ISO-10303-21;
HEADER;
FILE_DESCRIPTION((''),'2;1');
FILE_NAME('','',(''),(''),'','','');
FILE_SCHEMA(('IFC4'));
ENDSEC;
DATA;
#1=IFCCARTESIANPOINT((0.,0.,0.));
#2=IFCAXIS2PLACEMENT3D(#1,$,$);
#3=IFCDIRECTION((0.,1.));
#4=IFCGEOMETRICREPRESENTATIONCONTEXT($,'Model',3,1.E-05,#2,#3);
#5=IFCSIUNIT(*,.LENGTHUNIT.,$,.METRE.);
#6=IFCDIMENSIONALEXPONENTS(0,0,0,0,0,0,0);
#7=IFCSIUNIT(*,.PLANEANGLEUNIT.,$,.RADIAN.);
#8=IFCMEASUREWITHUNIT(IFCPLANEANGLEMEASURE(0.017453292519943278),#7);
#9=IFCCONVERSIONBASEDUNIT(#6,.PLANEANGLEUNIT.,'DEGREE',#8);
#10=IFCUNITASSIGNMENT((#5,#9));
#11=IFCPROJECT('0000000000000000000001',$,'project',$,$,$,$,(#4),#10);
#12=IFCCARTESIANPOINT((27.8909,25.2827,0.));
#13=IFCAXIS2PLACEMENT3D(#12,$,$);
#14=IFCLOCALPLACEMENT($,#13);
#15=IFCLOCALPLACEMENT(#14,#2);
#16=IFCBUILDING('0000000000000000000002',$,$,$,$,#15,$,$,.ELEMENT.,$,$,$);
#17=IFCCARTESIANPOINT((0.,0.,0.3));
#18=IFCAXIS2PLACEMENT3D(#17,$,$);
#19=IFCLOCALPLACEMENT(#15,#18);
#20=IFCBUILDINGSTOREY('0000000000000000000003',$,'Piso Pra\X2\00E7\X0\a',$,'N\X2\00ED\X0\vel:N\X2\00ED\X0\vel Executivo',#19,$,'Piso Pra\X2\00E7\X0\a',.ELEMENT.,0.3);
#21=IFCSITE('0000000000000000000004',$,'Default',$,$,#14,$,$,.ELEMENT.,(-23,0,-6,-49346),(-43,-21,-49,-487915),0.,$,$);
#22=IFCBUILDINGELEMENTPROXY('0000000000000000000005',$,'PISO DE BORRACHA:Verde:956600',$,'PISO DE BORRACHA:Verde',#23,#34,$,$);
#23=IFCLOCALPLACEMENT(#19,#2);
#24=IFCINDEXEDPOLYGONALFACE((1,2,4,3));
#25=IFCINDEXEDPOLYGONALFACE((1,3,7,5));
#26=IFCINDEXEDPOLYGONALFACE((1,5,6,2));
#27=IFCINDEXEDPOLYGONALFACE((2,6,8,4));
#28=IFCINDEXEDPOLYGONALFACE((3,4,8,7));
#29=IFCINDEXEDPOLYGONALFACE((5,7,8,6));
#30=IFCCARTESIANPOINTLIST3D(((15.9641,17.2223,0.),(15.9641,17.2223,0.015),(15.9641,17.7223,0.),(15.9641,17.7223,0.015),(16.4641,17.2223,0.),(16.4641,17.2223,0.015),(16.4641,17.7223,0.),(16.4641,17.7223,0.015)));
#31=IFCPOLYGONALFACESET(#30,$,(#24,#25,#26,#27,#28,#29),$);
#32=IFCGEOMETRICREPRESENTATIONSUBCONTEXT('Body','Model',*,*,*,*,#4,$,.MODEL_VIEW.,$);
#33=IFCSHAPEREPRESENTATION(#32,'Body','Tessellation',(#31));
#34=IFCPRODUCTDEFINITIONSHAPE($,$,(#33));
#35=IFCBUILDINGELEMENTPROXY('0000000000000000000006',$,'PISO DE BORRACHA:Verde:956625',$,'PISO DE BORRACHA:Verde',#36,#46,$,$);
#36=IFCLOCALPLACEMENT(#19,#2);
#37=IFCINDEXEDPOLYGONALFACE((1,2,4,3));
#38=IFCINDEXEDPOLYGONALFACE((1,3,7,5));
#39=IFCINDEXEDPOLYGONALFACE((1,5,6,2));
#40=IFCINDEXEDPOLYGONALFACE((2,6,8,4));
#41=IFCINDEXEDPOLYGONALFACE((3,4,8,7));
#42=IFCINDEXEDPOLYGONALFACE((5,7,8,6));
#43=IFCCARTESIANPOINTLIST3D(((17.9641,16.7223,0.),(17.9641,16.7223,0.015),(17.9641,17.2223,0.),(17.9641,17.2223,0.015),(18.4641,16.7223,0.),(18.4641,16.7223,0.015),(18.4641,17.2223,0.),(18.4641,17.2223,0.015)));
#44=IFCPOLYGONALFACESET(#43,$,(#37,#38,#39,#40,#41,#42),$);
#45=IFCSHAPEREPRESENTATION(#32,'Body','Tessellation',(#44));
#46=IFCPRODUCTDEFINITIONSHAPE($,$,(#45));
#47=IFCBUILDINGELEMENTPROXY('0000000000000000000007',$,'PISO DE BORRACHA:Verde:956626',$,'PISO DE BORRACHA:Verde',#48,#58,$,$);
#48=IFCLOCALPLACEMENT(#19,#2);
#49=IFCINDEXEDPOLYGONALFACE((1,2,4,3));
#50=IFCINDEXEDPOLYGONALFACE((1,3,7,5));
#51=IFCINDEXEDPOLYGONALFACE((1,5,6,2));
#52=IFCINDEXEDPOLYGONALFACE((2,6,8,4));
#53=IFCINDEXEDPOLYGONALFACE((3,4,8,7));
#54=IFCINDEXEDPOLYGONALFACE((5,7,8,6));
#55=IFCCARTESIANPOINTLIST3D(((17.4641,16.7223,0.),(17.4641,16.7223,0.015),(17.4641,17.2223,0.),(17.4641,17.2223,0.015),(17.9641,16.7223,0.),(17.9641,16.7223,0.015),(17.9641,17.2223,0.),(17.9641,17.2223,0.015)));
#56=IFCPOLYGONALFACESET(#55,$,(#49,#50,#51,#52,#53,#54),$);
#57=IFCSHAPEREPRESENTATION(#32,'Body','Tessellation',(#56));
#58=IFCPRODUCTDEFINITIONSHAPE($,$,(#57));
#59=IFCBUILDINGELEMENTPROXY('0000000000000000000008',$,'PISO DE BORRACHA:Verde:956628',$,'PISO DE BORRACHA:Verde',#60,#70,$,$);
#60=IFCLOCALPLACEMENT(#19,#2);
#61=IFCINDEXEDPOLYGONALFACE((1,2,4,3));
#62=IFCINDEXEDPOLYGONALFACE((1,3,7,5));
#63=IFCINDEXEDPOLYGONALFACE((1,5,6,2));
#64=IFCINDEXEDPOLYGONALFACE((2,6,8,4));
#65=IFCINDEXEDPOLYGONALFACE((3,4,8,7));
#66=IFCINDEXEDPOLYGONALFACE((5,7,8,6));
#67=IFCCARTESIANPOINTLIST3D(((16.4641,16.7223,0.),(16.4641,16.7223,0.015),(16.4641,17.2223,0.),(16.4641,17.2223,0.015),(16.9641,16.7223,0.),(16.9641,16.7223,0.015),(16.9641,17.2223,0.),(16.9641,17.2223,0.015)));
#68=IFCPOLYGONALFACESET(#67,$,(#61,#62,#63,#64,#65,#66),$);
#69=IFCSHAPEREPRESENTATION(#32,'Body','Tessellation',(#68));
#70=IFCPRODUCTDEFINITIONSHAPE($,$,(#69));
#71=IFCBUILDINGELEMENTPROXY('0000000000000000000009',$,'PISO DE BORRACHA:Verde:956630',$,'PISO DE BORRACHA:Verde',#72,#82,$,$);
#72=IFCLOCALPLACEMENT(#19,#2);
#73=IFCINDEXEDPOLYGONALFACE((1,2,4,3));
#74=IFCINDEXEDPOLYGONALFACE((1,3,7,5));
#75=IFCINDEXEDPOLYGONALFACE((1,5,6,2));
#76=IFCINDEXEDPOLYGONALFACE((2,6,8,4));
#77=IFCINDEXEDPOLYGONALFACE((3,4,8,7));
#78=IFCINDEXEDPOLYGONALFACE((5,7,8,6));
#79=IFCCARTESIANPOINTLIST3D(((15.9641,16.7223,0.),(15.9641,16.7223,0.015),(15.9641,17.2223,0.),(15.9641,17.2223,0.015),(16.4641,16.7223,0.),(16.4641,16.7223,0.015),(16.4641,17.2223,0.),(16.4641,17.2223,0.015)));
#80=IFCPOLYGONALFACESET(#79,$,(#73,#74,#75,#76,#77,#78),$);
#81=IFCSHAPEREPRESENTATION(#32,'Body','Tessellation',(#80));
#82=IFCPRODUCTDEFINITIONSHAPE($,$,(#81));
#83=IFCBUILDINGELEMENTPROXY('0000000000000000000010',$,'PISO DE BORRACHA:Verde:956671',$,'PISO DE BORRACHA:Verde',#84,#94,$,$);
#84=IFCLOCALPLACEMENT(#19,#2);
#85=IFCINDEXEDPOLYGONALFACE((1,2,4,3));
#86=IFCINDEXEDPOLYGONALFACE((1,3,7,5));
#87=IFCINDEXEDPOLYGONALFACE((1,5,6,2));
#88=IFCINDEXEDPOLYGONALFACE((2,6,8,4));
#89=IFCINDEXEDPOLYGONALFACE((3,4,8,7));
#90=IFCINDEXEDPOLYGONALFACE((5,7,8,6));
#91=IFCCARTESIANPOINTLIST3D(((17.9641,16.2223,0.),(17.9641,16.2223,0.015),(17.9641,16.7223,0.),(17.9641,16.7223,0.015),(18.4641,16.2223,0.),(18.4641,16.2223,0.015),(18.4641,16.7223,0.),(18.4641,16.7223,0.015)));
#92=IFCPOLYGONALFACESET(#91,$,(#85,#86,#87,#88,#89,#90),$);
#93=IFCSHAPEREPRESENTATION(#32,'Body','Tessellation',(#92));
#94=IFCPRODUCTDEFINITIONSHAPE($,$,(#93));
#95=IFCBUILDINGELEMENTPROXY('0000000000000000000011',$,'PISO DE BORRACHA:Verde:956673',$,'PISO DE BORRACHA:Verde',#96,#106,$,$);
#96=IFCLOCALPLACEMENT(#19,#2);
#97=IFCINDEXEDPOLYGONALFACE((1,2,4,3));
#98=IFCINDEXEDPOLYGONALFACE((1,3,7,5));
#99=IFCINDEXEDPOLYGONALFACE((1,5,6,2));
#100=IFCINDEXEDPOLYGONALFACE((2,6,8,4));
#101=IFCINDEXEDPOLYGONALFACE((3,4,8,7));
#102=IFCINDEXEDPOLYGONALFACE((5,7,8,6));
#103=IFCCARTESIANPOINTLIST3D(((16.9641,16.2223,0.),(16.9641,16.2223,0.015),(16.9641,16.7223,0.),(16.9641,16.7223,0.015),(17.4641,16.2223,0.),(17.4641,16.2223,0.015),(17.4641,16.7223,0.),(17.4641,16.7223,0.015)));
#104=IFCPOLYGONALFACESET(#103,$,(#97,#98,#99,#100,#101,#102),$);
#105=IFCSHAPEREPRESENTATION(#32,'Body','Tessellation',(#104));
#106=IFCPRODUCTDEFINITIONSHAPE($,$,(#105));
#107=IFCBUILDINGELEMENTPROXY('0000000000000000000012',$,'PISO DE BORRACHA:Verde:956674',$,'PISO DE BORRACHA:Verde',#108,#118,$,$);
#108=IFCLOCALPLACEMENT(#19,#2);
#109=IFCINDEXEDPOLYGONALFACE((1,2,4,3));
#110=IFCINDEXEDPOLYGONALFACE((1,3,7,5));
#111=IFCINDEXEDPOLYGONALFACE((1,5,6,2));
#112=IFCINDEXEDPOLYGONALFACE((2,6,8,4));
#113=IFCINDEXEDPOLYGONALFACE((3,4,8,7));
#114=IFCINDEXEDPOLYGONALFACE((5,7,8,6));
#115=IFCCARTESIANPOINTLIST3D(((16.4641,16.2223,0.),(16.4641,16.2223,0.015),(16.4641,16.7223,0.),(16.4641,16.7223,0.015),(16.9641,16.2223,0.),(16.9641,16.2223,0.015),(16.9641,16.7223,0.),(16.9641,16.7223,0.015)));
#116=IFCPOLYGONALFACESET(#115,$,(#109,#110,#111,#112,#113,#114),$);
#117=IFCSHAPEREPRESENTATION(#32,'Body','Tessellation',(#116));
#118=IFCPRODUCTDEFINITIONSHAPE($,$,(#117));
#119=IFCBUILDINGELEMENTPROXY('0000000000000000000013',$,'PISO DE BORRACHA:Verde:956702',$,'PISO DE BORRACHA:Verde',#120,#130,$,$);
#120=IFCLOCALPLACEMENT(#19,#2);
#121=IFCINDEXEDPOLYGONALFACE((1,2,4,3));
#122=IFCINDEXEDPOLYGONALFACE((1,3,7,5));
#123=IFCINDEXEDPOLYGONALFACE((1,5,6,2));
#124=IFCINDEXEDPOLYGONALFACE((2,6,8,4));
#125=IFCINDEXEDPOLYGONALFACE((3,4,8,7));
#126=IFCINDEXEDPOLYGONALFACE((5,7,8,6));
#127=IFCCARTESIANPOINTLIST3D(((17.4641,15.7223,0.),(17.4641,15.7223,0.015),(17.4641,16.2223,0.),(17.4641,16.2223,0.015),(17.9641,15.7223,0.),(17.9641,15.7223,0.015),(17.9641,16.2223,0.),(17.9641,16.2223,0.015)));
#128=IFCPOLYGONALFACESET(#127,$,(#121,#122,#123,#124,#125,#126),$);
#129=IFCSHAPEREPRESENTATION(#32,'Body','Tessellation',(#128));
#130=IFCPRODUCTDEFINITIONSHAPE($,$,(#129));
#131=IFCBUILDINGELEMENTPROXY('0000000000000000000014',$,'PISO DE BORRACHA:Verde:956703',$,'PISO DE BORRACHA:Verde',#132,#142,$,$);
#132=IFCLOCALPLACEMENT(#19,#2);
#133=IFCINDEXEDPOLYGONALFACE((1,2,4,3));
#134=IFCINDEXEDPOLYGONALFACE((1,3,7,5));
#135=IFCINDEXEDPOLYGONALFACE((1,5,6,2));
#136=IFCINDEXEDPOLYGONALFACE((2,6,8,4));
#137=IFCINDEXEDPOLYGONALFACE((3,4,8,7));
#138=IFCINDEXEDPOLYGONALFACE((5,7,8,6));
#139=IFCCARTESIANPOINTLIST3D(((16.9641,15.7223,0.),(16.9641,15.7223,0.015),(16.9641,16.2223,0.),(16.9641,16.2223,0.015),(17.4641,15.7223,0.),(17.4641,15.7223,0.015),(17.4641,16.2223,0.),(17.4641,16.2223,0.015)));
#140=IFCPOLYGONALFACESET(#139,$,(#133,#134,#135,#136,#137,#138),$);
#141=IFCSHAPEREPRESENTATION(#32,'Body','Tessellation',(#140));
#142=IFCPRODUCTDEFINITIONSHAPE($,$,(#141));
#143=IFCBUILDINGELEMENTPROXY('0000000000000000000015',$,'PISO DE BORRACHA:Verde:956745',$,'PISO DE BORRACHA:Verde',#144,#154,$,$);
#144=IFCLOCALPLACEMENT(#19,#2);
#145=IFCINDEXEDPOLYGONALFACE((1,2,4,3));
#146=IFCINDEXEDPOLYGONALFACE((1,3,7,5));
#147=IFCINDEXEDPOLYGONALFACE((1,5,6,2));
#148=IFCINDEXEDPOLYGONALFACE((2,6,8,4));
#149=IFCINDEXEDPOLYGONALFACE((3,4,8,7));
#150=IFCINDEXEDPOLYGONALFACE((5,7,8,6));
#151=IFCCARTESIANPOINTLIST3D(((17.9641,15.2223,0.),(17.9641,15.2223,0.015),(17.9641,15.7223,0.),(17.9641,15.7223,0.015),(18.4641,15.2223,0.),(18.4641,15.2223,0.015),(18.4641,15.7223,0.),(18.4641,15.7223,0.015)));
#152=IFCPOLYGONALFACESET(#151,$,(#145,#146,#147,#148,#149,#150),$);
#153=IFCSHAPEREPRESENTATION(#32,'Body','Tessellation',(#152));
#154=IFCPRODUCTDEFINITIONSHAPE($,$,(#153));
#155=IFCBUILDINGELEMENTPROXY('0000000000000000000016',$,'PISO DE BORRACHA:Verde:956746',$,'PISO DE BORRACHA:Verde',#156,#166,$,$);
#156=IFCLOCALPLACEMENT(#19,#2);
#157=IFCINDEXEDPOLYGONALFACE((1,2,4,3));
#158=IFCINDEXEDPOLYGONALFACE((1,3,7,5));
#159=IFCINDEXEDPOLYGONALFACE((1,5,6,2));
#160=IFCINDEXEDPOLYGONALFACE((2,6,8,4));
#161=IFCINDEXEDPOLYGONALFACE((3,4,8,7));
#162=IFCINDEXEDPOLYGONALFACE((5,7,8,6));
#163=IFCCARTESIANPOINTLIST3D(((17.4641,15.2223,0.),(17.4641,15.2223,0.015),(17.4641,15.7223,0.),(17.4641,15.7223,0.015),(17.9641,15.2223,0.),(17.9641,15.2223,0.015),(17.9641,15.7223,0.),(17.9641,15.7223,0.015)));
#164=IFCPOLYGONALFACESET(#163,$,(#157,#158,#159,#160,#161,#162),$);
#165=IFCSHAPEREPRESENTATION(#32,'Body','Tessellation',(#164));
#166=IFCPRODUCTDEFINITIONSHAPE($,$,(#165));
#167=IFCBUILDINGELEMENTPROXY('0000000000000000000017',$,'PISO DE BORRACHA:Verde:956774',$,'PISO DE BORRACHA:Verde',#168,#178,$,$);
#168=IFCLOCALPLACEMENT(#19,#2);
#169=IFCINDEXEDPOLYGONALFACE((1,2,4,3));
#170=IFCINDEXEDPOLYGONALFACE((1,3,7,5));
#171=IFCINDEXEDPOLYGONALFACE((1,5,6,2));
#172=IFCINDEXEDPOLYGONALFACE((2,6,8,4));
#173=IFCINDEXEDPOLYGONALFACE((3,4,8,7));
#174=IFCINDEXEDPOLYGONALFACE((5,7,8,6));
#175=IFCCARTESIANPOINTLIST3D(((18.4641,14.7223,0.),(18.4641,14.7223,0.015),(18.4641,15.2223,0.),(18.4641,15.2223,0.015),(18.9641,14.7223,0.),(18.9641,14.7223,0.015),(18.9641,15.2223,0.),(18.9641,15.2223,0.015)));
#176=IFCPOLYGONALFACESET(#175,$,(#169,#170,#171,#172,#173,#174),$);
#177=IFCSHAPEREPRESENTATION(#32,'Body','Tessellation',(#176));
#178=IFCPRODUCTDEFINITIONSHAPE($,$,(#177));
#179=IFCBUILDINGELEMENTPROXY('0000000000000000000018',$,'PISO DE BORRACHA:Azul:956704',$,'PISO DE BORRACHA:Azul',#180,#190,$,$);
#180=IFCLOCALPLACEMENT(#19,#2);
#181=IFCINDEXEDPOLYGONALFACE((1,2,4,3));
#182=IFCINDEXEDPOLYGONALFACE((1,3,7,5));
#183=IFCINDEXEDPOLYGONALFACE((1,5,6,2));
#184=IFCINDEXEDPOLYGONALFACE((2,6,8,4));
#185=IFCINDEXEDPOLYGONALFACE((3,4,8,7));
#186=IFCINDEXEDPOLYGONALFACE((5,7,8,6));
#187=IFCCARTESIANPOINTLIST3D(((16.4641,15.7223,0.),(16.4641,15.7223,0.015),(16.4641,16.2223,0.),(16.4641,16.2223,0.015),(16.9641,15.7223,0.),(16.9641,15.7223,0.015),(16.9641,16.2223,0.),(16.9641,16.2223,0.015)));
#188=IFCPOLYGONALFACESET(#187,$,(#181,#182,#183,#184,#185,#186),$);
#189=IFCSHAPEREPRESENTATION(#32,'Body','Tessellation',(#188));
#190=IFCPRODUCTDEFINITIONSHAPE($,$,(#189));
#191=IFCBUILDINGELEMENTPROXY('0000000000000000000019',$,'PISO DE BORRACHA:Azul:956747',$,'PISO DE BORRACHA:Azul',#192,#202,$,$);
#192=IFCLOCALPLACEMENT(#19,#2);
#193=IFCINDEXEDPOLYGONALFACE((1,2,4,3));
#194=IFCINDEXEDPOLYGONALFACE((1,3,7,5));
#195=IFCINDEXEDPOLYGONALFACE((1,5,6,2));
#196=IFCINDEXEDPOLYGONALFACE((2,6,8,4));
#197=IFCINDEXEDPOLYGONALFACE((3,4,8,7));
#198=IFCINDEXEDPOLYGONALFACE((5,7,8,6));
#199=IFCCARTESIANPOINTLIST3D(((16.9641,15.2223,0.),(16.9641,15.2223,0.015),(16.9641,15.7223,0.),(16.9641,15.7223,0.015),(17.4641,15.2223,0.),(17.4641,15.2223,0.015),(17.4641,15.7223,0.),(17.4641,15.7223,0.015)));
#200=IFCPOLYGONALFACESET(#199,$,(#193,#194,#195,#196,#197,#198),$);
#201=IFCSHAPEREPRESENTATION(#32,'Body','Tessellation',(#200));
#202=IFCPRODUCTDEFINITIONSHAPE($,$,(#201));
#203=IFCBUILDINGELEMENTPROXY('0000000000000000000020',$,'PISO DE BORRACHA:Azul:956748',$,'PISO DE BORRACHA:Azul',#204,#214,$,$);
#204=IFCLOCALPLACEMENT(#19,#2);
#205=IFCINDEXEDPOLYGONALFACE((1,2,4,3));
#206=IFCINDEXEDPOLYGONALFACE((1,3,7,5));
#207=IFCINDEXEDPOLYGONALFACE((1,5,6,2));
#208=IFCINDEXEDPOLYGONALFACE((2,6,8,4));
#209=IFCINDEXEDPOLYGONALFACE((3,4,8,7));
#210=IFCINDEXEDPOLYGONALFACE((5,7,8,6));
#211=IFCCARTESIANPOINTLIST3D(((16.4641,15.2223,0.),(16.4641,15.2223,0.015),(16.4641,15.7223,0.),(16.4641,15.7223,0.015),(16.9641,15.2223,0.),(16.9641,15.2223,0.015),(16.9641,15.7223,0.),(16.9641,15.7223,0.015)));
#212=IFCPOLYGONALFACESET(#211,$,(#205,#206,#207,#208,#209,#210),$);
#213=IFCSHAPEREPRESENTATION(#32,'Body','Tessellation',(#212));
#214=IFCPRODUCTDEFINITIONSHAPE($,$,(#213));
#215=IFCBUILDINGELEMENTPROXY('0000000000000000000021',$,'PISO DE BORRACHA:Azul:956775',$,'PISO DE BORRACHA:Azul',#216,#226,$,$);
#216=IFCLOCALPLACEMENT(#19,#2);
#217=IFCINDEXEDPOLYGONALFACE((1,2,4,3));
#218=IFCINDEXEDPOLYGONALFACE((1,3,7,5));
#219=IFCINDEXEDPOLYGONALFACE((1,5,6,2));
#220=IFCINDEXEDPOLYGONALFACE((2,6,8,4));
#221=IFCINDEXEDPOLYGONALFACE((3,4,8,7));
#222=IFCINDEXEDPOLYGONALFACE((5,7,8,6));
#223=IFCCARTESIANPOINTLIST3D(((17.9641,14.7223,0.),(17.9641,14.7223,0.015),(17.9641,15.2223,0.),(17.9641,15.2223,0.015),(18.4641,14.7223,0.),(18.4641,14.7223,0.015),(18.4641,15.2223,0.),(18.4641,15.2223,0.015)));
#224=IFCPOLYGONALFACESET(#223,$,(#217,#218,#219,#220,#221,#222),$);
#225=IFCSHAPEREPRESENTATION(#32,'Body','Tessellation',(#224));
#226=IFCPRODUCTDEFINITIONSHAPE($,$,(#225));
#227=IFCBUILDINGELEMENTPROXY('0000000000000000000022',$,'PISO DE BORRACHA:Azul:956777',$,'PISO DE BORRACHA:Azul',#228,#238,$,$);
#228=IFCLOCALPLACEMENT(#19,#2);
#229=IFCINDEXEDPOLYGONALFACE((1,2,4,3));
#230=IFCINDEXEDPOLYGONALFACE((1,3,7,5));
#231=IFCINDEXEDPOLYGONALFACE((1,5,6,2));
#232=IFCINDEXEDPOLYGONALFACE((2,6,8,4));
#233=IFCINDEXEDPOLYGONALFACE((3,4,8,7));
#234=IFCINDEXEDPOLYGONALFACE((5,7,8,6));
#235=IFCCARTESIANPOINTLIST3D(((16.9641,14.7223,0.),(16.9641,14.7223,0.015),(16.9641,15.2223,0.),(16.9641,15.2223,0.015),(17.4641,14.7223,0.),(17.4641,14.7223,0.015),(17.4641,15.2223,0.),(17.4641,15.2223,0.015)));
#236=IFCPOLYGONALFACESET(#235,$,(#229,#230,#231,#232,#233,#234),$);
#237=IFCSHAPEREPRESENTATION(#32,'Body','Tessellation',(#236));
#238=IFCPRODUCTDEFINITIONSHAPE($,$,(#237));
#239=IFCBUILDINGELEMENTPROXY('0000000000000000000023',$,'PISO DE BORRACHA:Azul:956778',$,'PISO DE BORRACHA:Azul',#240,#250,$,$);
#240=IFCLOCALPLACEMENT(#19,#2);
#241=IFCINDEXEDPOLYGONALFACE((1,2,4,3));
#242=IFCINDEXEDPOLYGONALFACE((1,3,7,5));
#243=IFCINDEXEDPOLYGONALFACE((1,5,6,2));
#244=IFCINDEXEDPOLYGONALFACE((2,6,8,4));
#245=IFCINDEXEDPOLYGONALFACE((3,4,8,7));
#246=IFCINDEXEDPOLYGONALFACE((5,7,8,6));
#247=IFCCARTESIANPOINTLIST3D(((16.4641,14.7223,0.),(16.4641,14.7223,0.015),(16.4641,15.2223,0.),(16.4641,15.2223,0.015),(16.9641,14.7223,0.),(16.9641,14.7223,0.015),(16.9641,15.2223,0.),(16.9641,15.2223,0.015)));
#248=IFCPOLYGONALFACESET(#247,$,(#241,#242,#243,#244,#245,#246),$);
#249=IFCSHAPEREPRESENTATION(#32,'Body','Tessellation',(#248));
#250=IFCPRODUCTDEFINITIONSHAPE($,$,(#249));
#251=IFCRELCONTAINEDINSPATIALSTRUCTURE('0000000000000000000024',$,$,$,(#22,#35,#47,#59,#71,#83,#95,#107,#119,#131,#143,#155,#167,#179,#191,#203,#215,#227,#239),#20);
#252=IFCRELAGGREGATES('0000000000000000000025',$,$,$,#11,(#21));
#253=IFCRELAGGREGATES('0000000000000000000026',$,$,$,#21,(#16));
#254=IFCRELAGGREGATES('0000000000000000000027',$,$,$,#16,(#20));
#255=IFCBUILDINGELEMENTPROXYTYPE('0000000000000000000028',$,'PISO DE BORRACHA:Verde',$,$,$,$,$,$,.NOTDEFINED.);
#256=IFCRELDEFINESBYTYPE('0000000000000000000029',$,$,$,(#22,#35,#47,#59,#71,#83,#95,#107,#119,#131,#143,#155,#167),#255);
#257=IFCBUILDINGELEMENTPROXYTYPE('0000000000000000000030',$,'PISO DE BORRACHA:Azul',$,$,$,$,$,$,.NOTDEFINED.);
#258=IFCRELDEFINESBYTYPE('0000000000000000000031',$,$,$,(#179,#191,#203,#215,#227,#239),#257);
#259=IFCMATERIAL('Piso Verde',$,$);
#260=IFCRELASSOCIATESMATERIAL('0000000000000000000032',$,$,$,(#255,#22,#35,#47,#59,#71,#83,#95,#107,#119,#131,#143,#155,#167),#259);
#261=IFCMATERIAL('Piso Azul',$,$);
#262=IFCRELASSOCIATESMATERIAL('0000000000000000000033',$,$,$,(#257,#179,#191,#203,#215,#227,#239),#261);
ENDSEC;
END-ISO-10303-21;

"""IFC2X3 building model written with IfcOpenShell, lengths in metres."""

from ifc_helpers import new_model, entity, si_unit, converted_unit, direction, frame, origin, origin_2d_with_axis, place, context, subcontext, project, spatial, rectangle, extrude, source, transform, mapped, material, type_object, type_shapes, element, save


model = new_model("IFC2X3")

# Units and contexts
model_context = context("Model", 3, precision=1e-05, world=origin(), true_north=direction((0.0, 1.0)))
body_context = subcontext(model_context, "Body", "Model", "MODEL_VIEW")
ifc_project = project(units=[si_unit("LENGTHUNIT", "METRE"), converted_unit("PLANEANGLEUNIT", "DEGREE", entity("IfcPlaneAngleMeasure", 0.017453292519943278), si_unit("PLANEANGLEUNIT", "RADIAN"), dimensions=[0, 0, 0, 0, 0, 0, 0])], contexts=[model_context])

# Site, building, storey
site_placement = place(None, frame((27.8909, 25.2827, 0.0)))
site = spatial("IfcSite", under=ifc_project, at=site_placement, Name="Default", CompositionType="ELEMENT", RefLatitude=(-23, 0, -6, -49346), RefLongitude=(-43, -21, -49, -487915), RefElevation=0.0)
building_placement = place(site_placement, origin())
building = spatial("IfcBuilding", under=site, at=building_placement, CompositionType="ELEMENT")
storey_placement = place(building_placement, frame((0.0, 0.0, 0.3)))
storey = spatial("IfcBuildingStorey", under=building, at=storey_placement, Name="Piso Praça", ObjectType="Nível:Nível Executivo", LongName="Piso Praça", CompositionType="ELEMENT", Elevation=0.3)

# Building element proxies
ifc_material_1 = material(Name="Piso Verde")
building_element_proxy_type_1 = type_object("IfcBuildingElementProxyType", Name="PISO DE BORRACHA:Verde", PredefinedType="NOTDEFINED", material=ifc_material_1)
shared_shape_1 = source(origin(), body_context, "Body", "SweptSolid", [
    extrude(rectangle(XDim=0.5, YDim=0.5, at=origin_2d_with_axis()), frame((0.25, 0.25, 0.0), z_axis=(0.0, 0.0, 1.0), x_axis=(-1.0, 0.0, 0.0)), (0.0, 0.0, 1.0), 0.015),
])
type_shapes(building_element_proxy_type_1, [shared_shape_1])
for number, where, name in (
    (1, (15.9641, 17.2223, 0.0), "PISO DE BORRACHA:Verde:956600"),
    (2, (17.9641, 16.7223, 0.0), "PISO DE BORRACHA:Verde:956625"),
    (3, (17.4641, 16.7223, 0.0), "PISO DE BORRACHA:Verde:956626"),
    (4, (16.4641, 16.7223, 0.0), "PISO DE BORRACHA:Verde:956628"),
    (5, (15.9641, 16.7223, 0.0), "PISO DE BORRACHA:Verde:956630"),
    (6, (17.9641, 16.2223, 0.0), "PISO DE BORRACHA:Verde:956671"),
    (7, (16.9641, 16.2223, 0.0), "PISO DE BORRACHA:Verde:956673"),
    (8, (16.4641, 16.2223, 0.0), "PISO DE BORRACHA:Verde:956674"),
    (9, (17.4641, 15.7223, 0.0), "PISO DE BORRACHA:Verde:956702"),
    (10, (16.9641, 15.7223, 0.0), "PISO DE BORRACHA:Verde:956703"),
    (11, (17.9641, 15.2223, 0.0), "PISO DE BORRACHA:Verde:956745"),
    (12, (17.4641, 15.2223, 0.0), "PISO DE BORRACHA:Verde:956746"),
    (13, (18.4641, 14.7223, 0.0), "PISO DE BORRACHA:Verde:956774"),
):
    element("IfcBuildingElementProxy", number, at=place(storey_placement, frame(where)), inside=storey, type_object=building_element_proxy_type_1, material=ifc_material_1, Name=name, ObjectType="PISO DE BORRACHA:Verde", context=body_context, shape_type="MappedRepresentation", body=[
        mapped(shared_shape_1, transform((0.0, 0.0, 0.0), scale=1.0)),
    ])
ifc_material_2 = material(Name="Piso Azul")
building_element_proxy_type_2 = type_object("IfcBuildingElementProxyType", Name="PISO DE BORRACHA:Azul", PredefinedType="NOTDEFINED", material=ifc_material_2)
shared_shape_2 = source(origin(), body_context, "Body", "SweptSolid", [
    extrude(rectangle(XDim=0.5, YDim=0.5, at=origin_2d_with_axis()), frame((0.25, 0.25, 0.0), z_axis=(0.0, 0.0, 1.0), x_axis=(-1.0, 0.0, 0.0)), (0.0, 0.0, 1.0), 0.015),
])
type_shapes(building_element_proxy_type_2, [shared_shape_2])
for number, where, name in (
    (14, (16.4641, 15.7223, 0.0), "PISO DE BORRACHA:Azul:956704"),
    (15, (16.9641, 15.2223, 0.0), "PISO DE BORRACHA:Azul:956747"),
    (16, (16.4641, 15.2223, 0.0), "PISO DE BORRACHA:Azul:956748"),
    (17, (17.9641, 14.7223, 0.0), "PISO DE BORRACHA:Azul:956775"),
    (18, (16.9641, 14.7223, 0.0), "PISO DE BORRACHA:Azul:956777"),
    (19, (16.4641, 14.7223, 0.0), "PISO DE BORRACHA:Azul:956778"),
):
    element("IfcBuildingElementProxy", number, at=place(storey_placement, frame(where)), inside=storey, type_object=building_element_proxy_type_2, material=ifc_material_2, Name=name, ObjectType="PISO DE BORRACHA:Azul", context=body_context, shape_type="MappedRepresentation", body=[
        mapped(shared_shape_2, transform((0.0, 0.0, 0.0), scale=1.0)),
    ])

save(model, "model.ifc")
